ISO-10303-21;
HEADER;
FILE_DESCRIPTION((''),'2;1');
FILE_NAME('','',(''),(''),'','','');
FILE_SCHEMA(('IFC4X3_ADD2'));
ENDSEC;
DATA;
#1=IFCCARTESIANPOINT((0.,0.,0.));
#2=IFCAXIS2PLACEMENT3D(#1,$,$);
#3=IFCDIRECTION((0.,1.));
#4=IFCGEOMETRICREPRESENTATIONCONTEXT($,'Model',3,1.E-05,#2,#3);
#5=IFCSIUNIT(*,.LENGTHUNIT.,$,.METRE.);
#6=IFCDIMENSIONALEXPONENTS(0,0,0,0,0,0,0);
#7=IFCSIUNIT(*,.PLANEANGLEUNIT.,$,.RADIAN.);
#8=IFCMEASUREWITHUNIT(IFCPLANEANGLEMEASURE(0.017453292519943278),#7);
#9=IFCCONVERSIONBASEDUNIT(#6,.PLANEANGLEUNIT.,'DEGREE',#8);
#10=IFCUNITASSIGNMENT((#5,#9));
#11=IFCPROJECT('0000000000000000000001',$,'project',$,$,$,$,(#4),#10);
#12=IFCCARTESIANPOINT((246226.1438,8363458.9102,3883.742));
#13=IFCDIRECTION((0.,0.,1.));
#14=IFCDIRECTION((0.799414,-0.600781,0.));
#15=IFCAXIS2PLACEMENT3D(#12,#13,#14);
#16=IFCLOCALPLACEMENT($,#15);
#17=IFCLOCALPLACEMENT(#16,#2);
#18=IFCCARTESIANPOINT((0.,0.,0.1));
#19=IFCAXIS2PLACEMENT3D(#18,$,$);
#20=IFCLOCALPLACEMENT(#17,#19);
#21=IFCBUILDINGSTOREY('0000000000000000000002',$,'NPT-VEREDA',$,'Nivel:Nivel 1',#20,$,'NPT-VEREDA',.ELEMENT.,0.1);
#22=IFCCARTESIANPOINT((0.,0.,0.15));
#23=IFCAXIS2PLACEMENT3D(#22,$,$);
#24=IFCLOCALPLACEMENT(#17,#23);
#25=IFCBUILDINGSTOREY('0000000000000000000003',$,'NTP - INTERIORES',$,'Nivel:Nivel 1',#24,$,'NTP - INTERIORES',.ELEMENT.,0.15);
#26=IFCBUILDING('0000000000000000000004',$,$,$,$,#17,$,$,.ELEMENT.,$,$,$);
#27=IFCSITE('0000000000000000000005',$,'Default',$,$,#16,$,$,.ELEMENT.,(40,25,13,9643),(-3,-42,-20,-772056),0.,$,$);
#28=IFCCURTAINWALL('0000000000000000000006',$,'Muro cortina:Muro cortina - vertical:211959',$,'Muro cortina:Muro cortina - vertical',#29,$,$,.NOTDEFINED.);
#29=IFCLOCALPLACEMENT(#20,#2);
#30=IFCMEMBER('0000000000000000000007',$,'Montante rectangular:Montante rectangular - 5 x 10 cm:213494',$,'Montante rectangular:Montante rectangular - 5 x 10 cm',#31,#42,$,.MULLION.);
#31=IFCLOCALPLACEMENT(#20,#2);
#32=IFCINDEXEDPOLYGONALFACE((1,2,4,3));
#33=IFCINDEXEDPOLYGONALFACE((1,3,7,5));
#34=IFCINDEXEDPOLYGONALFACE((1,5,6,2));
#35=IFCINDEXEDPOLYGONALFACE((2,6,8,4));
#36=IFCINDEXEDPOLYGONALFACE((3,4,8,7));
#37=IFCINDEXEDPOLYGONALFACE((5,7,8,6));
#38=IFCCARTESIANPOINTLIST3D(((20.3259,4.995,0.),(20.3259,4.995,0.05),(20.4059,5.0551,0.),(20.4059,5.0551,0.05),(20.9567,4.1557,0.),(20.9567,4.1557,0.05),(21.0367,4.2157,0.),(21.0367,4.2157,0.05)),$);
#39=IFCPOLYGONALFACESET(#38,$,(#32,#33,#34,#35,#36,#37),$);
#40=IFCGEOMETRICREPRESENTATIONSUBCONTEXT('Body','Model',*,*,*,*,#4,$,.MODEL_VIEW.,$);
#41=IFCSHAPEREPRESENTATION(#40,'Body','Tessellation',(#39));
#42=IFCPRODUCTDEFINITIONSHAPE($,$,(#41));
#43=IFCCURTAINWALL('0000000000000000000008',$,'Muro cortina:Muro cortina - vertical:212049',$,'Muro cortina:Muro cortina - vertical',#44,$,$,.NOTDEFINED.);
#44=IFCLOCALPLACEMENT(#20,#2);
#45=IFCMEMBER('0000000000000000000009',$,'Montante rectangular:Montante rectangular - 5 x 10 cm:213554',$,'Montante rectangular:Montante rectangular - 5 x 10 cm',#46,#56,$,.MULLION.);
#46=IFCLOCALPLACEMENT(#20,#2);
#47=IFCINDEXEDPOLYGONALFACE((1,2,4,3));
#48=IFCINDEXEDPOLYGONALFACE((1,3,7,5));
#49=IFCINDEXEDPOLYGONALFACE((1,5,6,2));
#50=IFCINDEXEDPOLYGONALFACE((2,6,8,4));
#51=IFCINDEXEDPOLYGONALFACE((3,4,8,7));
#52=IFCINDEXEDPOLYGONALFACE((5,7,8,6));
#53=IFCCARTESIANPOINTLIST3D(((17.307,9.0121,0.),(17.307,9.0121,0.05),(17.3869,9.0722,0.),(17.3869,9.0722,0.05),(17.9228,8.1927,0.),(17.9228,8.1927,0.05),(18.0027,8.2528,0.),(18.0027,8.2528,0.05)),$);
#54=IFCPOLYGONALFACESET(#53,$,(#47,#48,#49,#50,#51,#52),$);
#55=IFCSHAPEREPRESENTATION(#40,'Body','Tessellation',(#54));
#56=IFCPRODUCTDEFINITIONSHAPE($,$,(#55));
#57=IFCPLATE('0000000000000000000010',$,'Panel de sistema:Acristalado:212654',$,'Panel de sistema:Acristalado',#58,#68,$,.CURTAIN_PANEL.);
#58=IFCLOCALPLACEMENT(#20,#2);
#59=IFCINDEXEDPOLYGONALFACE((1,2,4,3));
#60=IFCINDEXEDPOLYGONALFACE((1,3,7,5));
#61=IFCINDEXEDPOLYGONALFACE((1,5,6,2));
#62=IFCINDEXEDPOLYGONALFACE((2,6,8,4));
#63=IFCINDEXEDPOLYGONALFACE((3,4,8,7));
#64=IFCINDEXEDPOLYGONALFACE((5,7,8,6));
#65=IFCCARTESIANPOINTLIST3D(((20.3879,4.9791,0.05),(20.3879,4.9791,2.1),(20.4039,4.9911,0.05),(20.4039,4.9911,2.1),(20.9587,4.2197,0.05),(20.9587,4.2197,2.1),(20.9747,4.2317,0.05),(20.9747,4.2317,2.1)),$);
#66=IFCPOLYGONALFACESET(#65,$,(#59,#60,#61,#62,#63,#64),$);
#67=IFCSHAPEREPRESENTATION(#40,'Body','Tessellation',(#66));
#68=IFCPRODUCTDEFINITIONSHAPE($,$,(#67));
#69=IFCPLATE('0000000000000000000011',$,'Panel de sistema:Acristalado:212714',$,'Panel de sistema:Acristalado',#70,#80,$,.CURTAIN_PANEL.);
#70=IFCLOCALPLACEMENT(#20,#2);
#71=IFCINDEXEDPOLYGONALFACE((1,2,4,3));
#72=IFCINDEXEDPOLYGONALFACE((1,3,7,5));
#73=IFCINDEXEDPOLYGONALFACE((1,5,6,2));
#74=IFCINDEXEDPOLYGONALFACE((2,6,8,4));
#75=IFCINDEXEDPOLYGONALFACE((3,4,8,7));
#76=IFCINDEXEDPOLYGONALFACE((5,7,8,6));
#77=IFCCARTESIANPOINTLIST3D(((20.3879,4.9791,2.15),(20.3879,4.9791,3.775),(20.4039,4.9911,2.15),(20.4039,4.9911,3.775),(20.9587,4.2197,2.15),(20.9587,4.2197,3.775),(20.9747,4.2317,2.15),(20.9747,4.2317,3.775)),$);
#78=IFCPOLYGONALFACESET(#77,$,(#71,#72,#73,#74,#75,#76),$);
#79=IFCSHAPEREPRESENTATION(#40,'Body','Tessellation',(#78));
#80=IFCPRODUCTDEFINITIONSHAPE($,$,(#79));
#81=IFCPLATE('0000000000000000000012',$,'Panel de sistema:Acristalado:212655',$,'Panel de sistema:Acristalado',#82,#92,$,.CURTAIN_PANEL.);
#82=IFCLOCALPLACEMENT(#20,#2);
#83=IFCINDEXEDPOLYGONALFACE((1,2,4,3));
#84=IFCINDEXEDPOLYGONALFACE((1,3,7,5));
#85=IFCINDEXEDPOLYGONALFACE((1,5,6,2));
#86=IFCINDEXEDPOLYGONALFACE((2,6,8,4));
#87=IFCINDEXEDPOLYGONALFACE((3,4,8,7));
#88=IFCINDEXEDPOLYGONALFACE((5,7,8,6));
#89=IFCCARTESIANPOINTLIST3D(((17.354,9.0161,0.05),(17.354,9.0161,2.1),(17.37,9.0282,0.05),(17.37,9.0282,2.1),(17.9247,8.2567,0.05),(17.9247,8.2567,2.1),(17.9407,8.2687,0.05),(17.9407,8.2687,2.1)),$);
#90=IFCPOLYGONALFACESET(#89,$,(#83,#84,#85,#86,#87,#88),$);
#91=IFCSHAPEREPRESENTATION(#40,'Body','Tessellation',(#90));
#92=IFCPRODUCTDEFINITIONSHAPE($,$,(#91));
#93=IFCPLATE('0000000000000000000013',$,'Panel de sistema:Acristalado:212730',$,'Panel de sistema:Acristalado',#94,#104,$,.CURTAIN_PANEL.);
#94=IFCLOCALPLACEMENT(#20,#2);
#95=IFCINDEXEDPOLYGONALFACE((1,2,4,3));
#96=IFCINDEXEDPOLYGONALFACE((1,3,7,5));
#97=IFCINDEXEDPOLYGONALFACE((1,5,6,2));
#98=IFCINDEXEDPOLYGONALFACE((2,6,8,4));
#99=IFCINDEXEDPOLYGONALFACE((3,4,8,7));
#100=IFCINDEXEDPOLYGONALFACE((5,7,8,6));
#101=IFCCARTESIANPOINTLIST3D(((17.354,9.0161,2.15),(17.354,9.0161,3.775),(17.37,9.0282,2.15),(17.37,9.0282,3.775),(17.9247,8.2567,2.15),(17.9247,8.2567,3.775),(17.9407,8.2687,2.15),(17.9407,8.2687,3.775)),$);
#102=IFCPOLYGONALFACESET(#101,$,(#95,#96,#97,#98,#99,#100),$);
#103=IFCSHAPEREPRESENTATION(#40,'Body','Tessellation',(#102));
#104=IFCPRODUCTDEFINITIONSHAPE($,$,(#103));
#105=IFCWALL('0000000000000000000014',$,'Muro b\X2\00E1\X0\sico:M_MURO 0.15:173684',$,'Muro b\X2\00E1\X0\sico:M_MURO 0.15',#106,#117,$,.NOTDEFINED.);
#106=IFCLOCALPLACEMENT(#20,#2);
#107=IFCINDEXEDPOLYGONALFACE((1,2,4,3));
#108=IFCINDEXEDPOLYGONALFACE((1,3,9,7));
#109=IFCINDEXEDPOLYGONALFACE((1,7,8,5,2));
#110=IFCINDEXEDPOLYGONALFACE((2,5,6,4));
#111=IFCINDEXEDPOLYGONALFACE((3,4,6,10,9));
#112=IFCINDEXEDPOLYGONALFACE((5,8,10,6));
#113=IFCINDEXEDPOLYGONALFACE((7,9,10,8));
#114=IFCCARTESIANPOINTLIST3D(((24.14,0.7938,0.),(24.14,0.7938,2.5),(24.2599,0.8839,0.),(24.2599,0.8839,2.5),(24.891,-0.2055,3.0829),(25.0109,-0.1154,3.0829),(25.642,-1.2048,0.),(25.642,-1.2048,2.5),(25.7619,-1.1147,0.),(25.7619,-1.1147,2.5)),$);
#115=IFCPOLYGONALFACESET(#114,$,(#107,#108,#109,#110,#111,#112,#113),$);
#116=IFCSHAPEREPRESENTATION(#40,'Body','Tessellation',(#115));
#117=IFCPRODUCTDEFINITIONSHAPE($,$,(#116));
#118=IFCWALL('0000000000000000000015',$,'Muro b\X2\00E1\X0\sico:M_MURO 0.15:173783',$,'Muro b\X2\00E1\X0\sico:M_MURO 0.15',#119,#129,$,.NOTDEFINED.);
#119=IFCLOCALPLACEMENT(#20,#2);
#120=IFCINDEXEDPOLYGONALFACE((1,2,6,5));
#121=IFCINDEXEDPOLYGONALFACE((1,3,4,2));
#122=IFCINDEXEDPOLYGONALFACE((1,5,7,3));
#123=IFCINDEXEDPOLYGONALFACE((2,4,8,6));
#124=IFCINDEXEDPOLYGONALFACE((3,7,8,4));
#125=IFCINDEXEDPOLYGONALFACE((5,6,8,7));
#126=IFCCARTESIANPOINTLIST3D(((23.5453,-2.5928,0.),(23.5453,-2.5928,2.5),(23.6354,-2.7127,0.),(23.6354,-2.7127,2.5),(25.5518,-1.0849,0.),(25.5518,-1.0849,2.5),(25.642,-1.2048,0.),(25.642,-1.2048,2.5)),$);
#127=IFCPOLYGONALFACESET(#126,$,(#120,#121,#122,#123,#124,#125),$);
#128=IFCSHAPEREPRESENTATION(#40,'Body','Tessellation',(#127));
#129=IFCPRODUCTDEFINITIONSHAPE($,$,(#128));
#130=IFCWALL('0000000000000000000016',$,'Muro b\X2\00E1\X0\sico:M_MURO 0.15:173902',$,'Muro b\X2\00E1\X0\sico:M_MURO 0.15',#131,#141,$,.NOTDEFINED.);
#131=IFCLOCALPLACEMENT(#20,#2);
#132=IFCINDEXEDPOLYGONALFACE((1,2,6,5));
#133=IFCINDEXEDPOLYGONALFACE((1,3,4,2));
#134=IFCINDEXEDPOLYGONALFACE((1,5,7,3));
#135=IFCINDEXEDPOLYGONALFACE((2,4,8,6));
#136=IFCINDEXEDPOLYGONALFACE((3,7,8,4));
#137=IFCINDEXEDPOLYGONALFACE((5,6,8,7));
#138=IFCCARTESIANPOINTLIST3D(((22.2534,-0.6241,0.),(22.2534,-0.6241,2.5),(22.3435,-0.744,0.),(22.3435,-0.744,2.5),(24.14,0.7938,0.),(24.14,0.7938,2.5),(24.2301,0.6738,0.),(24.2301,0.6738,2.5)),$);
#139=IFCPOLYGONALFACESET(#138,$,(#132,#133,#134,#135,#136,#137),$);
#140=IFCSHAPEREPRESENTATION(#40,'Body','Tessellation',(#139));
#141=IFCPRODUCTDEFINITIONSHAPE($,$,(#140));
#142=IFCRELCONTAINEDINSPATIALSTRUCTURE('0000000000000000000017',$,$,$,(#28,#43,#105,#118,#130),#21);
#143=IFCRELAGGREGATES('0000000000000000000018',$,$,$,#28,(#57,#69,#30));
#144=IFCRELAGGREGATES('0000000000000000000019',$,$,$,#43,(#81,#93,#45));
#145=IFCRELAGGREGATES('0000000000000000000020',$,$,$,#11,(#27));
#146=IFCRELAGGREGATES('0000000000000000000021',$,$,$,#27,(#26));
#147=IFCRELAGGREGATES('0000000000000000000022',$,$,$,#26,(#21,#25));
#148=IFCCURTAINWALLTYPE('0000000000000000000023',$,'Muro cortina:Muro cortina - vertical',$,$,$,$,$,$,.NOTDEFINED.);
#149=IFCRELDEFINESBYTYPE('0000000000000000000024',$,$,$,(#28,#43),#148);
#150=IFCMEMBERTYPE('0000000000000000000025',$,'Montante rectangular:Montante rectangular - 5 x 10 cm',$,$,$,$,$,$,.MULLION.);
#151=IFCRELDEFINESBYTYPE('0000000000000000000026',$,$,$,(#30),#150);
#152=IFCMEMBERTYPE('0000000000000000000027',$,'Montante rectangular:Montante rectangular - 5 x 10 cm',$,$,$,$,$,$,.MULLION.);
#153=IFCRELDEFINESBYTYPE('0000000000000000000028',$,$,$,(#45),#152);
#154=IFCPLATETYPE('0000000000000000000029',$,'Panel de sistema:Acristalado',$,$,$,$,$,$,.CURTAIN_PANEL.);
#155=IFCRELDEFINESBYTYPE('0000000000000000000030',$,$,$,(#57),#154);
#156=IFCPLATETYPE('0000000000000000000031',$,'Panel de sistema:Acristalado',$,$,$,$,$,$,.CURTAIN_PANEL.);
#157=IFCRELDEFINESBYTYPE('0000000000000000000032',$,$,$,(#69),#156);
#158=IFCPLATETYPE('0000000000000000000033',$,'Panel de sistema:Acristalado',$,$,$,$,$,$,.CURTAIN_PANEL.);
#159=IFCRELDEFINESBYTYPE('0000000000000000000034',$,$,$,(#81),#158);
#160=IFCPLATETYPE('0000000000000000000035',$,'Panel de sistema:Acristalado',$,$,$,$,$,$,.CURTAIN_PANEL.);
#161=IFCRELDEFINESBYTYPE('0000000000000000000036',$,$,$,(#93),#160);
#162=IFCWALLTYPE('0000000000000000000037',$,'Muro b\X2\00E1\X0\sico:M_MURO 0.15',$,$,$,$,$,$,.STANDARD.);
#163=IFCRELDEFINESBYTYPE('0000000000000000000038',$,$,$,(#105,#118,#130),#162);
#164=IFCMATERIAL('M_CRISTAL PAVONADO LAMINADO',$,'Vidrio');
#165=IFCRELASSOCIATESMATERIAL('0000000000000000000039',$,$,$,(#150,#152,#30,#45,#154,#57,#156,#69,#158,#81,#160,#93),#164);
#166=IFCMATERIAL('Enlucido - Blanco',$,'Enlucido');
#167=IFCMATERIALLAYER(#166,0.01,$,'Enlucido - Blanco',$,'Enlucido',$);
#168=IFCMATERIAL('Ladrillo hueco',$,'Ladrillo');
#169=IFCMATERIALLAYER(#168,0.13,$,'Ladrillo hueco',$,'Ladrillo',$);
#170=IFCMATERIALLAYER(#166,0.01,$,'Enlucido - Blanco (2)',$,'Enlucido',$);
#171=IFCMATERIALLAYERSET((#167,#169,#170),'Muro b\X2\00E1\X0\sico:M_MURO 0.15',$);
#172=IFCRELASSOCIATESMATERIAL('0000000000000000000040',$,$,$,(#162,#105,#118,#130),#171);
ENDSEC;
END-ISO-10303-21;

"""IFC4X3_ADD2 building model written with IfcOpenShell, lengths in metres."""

from ifc_helpers import new_model, entity, si_unit, converted_unit, direction, frame, frame_2d, origin, origin_2d_with_axis, place, context, subcontext, project, spatial, polyline, rectangle, outline, extrude, clip, bounded_halfspace, source, transform, mapped, material, layer, layer_set, material_profile, profile_set, profile_usage, type_object, type_shapes, element, aggregate, save


model = new_model("IFC4X3_ADD2")

# Units and contexts
model_context = context("Model", 3, precision=1e-05, world=origin(), true_north=direction((0.0, 1.0)))
body_context = subcontext(model_context, "Body", "Model", "MODEL_VIEW")
ifc_project = project(units=[si_unit("LENGTHUNIT", "METRE"), converted_unit("PLANEANGLEUNIT", "DEGREE", entity("IfcPlaneAngleMeasure", 0.017453292519943278), si_unit("PLANEANGLEUNIT", "RADIAN"), dimensions=[0, 0, 0, 0, 0, 0, 0])], contexts=[model_context])

# Site, building, storey
site_placement = place(None, frame((246226.1438, 8363458.9102, 3883.742), z_axis=(0.0, 0.0, 1.0), x_axis=(0.799414, -0.600781, 0.0)))
site = spatial("IfcSite", under=ifc_project, at=site_placement, Name="Default", CompositionType="ELEMENT", RefLatitude=(40, 25, 13, 9643), RefLongitude=(-3, -42, -20, -772056), RefElevation=0.0)
building_placement = place(site_placement, origin())
building = spatial("IfcBuilding", under=site, at=building_placement, CompositionType="ELEMENT")
storey_1_placement = place(building_placement, frame((0.0, 0.0, 0.1)))
storey_1 = spatial("IfcBuildingStorey", under=building, at=storey_1_placement, Name="NPT-VEREDA", ObjectType="Nivel:Nivel 1", LongName="NPT-VEREDA", CompositionType="ELEMENT", Elevation=0.1)

# Curtain walls, members
curtain_wall_type = type_object("IfcCurtainWallType", Name="Muro cortina:Muro cortina - vertical", PredefinedType="NOTDEFINED")
curtain_wall_1_placement = place(storey_1_placement, frame((0.0, 0.0, -0.1)))
curtain_wall_1 = element("IfcCurtainWall", 1, at=curtain_wall_1_placement, inside=storey_1, type_object=curtain_wall_type, Name="Muro cortina:Muro cortina - vertical:211959", ObjectType="Muro cortina:Muro cortina - vertical", PredefinedType="NOTDEFINED")
ifc_material_1 = material(Name="M_CRISTAL PAVONADO LAMINADO", Category="Vidrio")
ifc_material_profile = material_profile(ifc_material_1, outline(polyline([(-0.9872, -0.025), (0.948, -0.025), (0.948, 0.025), (-0.9087, 0.025), (-0.9872, -0.025)])), Name="Montante rectangular - 5 x 10 cm")
ifc_profile_set = profile_set([ifc_material_profile], Name="Montante rectangular - 5 x 10 cm")
ifc_profile_usage = profile_usage(ifc_profile_set)
member_type_1 = type_object("IfcMemberType", Name="Montante rectangular:Montante rectangular - 5 x 10 cm", PredefinedType="MULLION", material=ifc_profile_set)
shared_shape_1 = source(origin(), body_context, "Body", "SweptSolid", [
    extrude(rectangle(XDim=0.1, YDim=0.05, at=origin_2d_with_axis()), frame((-0.025, 0.0, -1.05), z_axis=(0.0, 0.0, 1.0), x_axis=(0.0, -1.0, 0.0)), (0.0, 0.0, 1.0), 1.05),
])
type_shapes(member_type_1, [shared_shape_1])
member_1_placement = place(curtain_wall_1_placement, frame((20.3659, 5.0251, 0.1), z_axis=(-0.60078, 0.799414, 0.0), x_axis=(0.0, 0.0, -1.0)))
member_1 = element("IfcMember", 2, at=member_1_placement, type_object=member_type_1, material=ifc_profile_usage, Name="Montante rectangular:Montante rectangular - 5 x 10 cm:213494", ObjectType="Montante rectangular:Montante rectangular - 5 x 10 cm", PredefinedType="MULLION", context=body_context, shape_type="MappedRepresentation", body=[
    mapped(shared_shape_1, transform((0.0, 0.0, 0.0), scale=1.0)),
])
curtain_wall_2_placement = place(storey_1_placement, frame((0.0, 0.0, -0.1)))
curtain_wall_2 = element("IfcCurtainWall", 3, at=curtain_wall_2_placement, inside=storey_1, type_object=curtain_wall_type, Name="Muro cortina:Muro cortina - vertical:212049", ObjectType="Muro cortina:Muro cortina - vertical", PredefinedType="NOTDEFINED")
member_type_2 = type_object("IfcMemberType", Name="Montante rectangular:Montante rectangular - 5 x 10 cm", PredefinedType="MULLION", material=ifc_profile_set)
shared_shape_2 = source(origin(), body_context, "Body", "SweptSolid", [
    extrude(rectangle(XDim=0.05, YDim=0.1, at=frame_2d((0.0, 0.0), x_axis=(1.0, 0.0))), frame((-0.025, 0.0, -1.025)), (0.0, 0.0, 1.0), 1.025),
])
type_shapes(member_type_2, [shared_shape_2])
member_2_placement = place(curtain_wall_2_placement, frame((17.9628, 8.2227, 0.1), z_axis=(0.60078, -0.799414, 0.0), x_axis=(0.0, 0.0, -1.0)))
member_2 = element("IfcMember", 4, at=member_2_placement, type_object=member_type_2, material=ifc_profile_usage, Name="Montante rectangular:Montante rectangular - 5 x 10 cm:213554", ObjectType="Montante rectangular:Montante rectangular - 5 x 10 cm", PredefinedType="MULLION", context=body_context, shape_type="MappedRepresentation", body=[
    mapped(shared_shape_2, transform((0.0, 0.0, 0.0), scale=1.0)),
])

# Plates
plate_type_1 = type_object("IfcPlateType", Name="Panel de sistema:Acristalado", PredefinedType="CURTAIN_PANEL", material=ifc_material_1)
shared_shape_3 = source(origin(), body_context, "Body", "SweptSolid", [
    extrude(rectangle(XDim=0.02, YDim=0.95, at=frame_2d((0.0, 0.0), x_axis=(1.0, 0.0))), frame((0.0, 0.0, 0.0), z_axis=(0.0, 0.0, 1.0), x_axis=(0.0, 1.0, 0.0)), (0.0, 0.0, 1.0), 2.05),
])
type_shapes(plate_type_1, [shared_shape_3])
plate_1_placement = place(curtain_wall_1_placement, frame((20.6813, 4.6054, 0.15), z_axis=(0.0, 0.0, 1.0), x_axis=(0.60078, -0.799414, 0.0)))
plate_1 = element("IfcPlate", 5, at=plate_1_placement, type_object=plate_type_1, material=ifc_material_1, Name="Panel de sistema:Acristalado:212654", ObjectType="Panel de sistema:Acristalado", PredefinedType="CURTAIN_PANEL", context=body_context, shape_type="MappedRepresentation", body=[
    mapped(shared_shape_3, transform((0.0, 0.0, 0.0), scale=1.0)),
])
plate_type_2 = type_object("IfcPlateType", Name="Panel de sistema:Acristalado", PredefinedType="CURTAIN_PANEL", material=ifc_material_1)
shared_shape_4 = source(origin(), body_context, "Body", "SweptSolid", [
    extrude(rectangle(XDim=0.02, YDim=0.95, at=frame_2d((0.0, 0.0), x_axis=(1.0, 0.0))), frame((0.0, 0.0, 0.0), z_axis=(0.0, 0.0, 1.0), x_axis=(0.0, 1.0, 0.0)), (0.0, 0.0, 1.0), 1.625),
])
type_shapes(plate_type_2, [shared_shape_4])
plate_2_placement = place(curtain_wall_1_placement, frame((20.6813, 4.6054, 2.25), z_axis=(0.0, 0.0, 1.0), x_axis=(0.60078, -0.799414, 0.0)))
plate_2 = element("IfcPlate", 6, at=plate_2_placement, type_object=plate_type_2, material=ifc_material_1, Name="Panel de sistema:Acristalado:212714", ObjectType="Panel de sistema:Acristalado", PredefinedType="CURTAIN_PANEL", context=body_context, shape_type="MappedRepresentation", body=[
    mapped(shared_shape_4, transform((0.0, 0.0, 0.0), scale=1.0)),
])
aggregate(curtain_wall_1, [plate_1, plate_2, member_1])
plate_type_3 = type_object("IfcPlateType", Name="Panel de sistema:Acristalado", PredefinedType="CURTAIN_PANEL", material=ifc_material_1)
shared_shape_5 = source(origin(), body_context, "Body", "SweptSolid", [
    extrude(rectangle(XDim=0.02, YDim=0.95, at=frame_2d((0.0, 0.0), x_axis=(1.0, 0.0))), frame((0.0, 0.0, 0.0), z_axis=(0.0, 0.0, 1.0), x_axis=(0.0, 1.0, 0.0)), (0.0, 0.0, 1.0), 2.05),
])
type_shapes(plate_type_3, [shared_shape_5])
plate_3_placement = place(curtain_wall_2_placement, frame((17.6474, 8.6424, 0.15), z_axis=(0.0, 0.0, 1.0), x_axis=(-0.60078, 0.799414, 0.0)))
plate_3 = element("IfcPlate", 7, at=plate_3_placement, type_object=plate_type_3, material=ifc_material_1, Name="Panel de sistema:Acristalado:212655", ObjectType="Panel de sistema:Acristalado", PredefinedType="CURTAIN_PANEL", context=body_context, shape_type="MappedRepresentation", body=[
    mapped(shared_shape_5, transform((0.0, 0.0, 0.0), scale=1.0)),
])
plate_type_4 = type_object("IfcPlateType", Name="Panel de sistema:Acristalado", PredefinedType="CURTAIN_PANEL", material=ifc_material_1)
shared_shape_6 = source(origin(), body_context, "Body", "SweptSolid", [
    extrude(rectangle(XDim=0.02, YDim=0.95, at=frame_2d((0.0, 0.0), x_axis=(1.0, 0.0))), frame((0.0, 0.0, 0.0), z_axis=(0.0, 0.0, 1.0), x_axis=(0.0, 1.0, 0.0)), (0.0, 0.0, 1.0), 1.625),
])
type_shapes(plate_type_4, [shared_shape_6])
plate_4_placement = place(curtain_wall_2_placement, frame((17.6474, 8.6424, 2.25), z_axis=(0.0, 0.0, 1.0), x_axis=(-0.60078, 0.799414, 0.0)))
plate_4 = element("IfcPlate", 8, at=plate_4_placement, type_object=plate_type_4, material=ifc_material_1, Name="Panel de sistema:Acristalado:212730", ObjectType="Panel de sistema:Acristalado", PredefinedType="CURTAIN_PANEL", context=body_context, shape_type="MappedRepresentation", body=[
    mapped(shared_shape_6, transform((0.0, 0.0, 0.0), scale=1.0)),
])
aggregate(curtain_wall_2, [plate_3, plate_4, member_2])

# Shared definitions
ifc_material_2 = material(Name="Enlucido - Blanco", Category="Enlucido")
ifc_layer_1 = layer(ifc_material_2, 0.01, Name="Enlucido - Blanco", Category="Enlucido")
ifc_material_3 = material(Name="Ladrillo hueco", Category="Ladrillo")
ifc_layer_2 = layer(ifc_material_3, 0.13, Name="Ladrillo hueco", Category="Ladrillo")
ifc_layer_3 = layer(ifc_material_2, 0.01, Name="Enlucido - Blanco (2)", Category="Enlucido")
ifc_layer_set = layer_set([ifc_layer_1, ifc_layer_2, ifc_layer_3], Name="Muro básico:M_MURO 0.15")
wall_type = type_object("IfcWallType", Name="Muro básico:M_MURO 0.15", PredefinedType="STANDARD", material=ifc_layer_set)

# Shared definitions
storey_2_placement = place(building_placement, frame((0.0, 0.0, 0.15)))
storey_2 = spatial("IfcBuildingStorey", under=building, at=storey_2_placement, Name="NTP - INTERIORES", ObjectType="Nivel:Nivel 1", LongName="NTP - INTERIORES", CompositionType="ELEMENT", Elevation=0.15)

# Walls
wall_1_placement = place(storey_1_placement, frame((24.2, 0.8388, 0.0), z_axis=(0.0, 0.0, 1.0), x_axis=(0.60078, -0.799414, 0.0)))
element("IfcWall", 9, at=wall_1_placement, inside=storey_1, type_object=wall_type, material=ifc_layer_set, Name="Muro básico:M_MURO 0.15:173684", ObjectType="Muro básico:M_MURO 0.15", PredefinedType="NOTDEFINED", context=body_context, shape_type="Clipping", body=[
    clip(clip(extrude(rectangle(XDim=2.5, YDim=0.15, at=frame_2d((1.25, 0.0), x_axis=(-1.0, 0.0))), origin(), (0.0, 0.0, 1.0), 3.0829), bounded_halfspace(frame((1.25, -0.075, 3.0829), z_axis=(-0.422618, 0.0, -0.906308), x_axis=(0.0, -1.0, 0.0)), True, frame((1.25, -0.075, 3.0829)), polyline([(0.0, 0.0), (1.25, 0.0), (1.25, 0.15), (0.0, 0.15), (0.0, 0.0)]))), bounded_halfspace(frame((0.0, -0.075, 2.5), z_axis=(0.422618, 0.0, -0.906308), x_axis=(0.0, -1.0, 0.0)), True, frame((0.0, -0.075, 2.5)), polyline([(0.0, 0.0), (1.25, 0.0), (1.25, 0.15), (0.0, 0.15), (0.0, 0.0)]))),
])
wall_2_placement = place(storey_1_placement, frame((25.5969, -1.1448, 0.0), z_axis=(0.0, 0.0, 1.0), x_axis=(-0.799414, -0.60078, 0.0)))
element("IfcWall", 10, at=wall_2_placement, inside=storey_1, type_object=wall_type, material=ifc_layer_set, Name="Muro básico:M_MURO 0.15:173783", ObjectType="Muro básico:M_MURO 0.15", PredefinedType="NOTDEFINED", context=body_context, shape_type="SweptSolid", body=[
    extrude(rectangle(XDim=2.51, YDim=0.15, at=frame_2d((1.255, 0.0), x_axis=(-1.0, 0.0))), origin(), (0.0, 0.0, 1.0), 2.5),
])
wall_3_placement = place(storey_1_placement, frame((24.1851, 0.7338, 0.0), z_axis=(0.0, 0.0, 1.0), x_axis=(-0.799414, -0.60078, 0.0)))
element("IfcWall", 11, at=wall_3_placement, inside=storey_1, type_object=wall_type, material=ifc_layer_set, Name="Muro básico:M_MURO 0.15:173902", ObjectType="Muro básico:M_MURO 0.15", PredefinedType="NOTDEFINED", context=body_context, shape_type="SweptSolid", body=[
    extrude(rectangle(XDim=2.36, YDim=0.15, at=frame_2d((1.18, 0.0), x_axis=(-1.0, 0.0))), origin(), (0.0, 0.0, 1.0), 2.5),
])

save(model, "model.ifc")
